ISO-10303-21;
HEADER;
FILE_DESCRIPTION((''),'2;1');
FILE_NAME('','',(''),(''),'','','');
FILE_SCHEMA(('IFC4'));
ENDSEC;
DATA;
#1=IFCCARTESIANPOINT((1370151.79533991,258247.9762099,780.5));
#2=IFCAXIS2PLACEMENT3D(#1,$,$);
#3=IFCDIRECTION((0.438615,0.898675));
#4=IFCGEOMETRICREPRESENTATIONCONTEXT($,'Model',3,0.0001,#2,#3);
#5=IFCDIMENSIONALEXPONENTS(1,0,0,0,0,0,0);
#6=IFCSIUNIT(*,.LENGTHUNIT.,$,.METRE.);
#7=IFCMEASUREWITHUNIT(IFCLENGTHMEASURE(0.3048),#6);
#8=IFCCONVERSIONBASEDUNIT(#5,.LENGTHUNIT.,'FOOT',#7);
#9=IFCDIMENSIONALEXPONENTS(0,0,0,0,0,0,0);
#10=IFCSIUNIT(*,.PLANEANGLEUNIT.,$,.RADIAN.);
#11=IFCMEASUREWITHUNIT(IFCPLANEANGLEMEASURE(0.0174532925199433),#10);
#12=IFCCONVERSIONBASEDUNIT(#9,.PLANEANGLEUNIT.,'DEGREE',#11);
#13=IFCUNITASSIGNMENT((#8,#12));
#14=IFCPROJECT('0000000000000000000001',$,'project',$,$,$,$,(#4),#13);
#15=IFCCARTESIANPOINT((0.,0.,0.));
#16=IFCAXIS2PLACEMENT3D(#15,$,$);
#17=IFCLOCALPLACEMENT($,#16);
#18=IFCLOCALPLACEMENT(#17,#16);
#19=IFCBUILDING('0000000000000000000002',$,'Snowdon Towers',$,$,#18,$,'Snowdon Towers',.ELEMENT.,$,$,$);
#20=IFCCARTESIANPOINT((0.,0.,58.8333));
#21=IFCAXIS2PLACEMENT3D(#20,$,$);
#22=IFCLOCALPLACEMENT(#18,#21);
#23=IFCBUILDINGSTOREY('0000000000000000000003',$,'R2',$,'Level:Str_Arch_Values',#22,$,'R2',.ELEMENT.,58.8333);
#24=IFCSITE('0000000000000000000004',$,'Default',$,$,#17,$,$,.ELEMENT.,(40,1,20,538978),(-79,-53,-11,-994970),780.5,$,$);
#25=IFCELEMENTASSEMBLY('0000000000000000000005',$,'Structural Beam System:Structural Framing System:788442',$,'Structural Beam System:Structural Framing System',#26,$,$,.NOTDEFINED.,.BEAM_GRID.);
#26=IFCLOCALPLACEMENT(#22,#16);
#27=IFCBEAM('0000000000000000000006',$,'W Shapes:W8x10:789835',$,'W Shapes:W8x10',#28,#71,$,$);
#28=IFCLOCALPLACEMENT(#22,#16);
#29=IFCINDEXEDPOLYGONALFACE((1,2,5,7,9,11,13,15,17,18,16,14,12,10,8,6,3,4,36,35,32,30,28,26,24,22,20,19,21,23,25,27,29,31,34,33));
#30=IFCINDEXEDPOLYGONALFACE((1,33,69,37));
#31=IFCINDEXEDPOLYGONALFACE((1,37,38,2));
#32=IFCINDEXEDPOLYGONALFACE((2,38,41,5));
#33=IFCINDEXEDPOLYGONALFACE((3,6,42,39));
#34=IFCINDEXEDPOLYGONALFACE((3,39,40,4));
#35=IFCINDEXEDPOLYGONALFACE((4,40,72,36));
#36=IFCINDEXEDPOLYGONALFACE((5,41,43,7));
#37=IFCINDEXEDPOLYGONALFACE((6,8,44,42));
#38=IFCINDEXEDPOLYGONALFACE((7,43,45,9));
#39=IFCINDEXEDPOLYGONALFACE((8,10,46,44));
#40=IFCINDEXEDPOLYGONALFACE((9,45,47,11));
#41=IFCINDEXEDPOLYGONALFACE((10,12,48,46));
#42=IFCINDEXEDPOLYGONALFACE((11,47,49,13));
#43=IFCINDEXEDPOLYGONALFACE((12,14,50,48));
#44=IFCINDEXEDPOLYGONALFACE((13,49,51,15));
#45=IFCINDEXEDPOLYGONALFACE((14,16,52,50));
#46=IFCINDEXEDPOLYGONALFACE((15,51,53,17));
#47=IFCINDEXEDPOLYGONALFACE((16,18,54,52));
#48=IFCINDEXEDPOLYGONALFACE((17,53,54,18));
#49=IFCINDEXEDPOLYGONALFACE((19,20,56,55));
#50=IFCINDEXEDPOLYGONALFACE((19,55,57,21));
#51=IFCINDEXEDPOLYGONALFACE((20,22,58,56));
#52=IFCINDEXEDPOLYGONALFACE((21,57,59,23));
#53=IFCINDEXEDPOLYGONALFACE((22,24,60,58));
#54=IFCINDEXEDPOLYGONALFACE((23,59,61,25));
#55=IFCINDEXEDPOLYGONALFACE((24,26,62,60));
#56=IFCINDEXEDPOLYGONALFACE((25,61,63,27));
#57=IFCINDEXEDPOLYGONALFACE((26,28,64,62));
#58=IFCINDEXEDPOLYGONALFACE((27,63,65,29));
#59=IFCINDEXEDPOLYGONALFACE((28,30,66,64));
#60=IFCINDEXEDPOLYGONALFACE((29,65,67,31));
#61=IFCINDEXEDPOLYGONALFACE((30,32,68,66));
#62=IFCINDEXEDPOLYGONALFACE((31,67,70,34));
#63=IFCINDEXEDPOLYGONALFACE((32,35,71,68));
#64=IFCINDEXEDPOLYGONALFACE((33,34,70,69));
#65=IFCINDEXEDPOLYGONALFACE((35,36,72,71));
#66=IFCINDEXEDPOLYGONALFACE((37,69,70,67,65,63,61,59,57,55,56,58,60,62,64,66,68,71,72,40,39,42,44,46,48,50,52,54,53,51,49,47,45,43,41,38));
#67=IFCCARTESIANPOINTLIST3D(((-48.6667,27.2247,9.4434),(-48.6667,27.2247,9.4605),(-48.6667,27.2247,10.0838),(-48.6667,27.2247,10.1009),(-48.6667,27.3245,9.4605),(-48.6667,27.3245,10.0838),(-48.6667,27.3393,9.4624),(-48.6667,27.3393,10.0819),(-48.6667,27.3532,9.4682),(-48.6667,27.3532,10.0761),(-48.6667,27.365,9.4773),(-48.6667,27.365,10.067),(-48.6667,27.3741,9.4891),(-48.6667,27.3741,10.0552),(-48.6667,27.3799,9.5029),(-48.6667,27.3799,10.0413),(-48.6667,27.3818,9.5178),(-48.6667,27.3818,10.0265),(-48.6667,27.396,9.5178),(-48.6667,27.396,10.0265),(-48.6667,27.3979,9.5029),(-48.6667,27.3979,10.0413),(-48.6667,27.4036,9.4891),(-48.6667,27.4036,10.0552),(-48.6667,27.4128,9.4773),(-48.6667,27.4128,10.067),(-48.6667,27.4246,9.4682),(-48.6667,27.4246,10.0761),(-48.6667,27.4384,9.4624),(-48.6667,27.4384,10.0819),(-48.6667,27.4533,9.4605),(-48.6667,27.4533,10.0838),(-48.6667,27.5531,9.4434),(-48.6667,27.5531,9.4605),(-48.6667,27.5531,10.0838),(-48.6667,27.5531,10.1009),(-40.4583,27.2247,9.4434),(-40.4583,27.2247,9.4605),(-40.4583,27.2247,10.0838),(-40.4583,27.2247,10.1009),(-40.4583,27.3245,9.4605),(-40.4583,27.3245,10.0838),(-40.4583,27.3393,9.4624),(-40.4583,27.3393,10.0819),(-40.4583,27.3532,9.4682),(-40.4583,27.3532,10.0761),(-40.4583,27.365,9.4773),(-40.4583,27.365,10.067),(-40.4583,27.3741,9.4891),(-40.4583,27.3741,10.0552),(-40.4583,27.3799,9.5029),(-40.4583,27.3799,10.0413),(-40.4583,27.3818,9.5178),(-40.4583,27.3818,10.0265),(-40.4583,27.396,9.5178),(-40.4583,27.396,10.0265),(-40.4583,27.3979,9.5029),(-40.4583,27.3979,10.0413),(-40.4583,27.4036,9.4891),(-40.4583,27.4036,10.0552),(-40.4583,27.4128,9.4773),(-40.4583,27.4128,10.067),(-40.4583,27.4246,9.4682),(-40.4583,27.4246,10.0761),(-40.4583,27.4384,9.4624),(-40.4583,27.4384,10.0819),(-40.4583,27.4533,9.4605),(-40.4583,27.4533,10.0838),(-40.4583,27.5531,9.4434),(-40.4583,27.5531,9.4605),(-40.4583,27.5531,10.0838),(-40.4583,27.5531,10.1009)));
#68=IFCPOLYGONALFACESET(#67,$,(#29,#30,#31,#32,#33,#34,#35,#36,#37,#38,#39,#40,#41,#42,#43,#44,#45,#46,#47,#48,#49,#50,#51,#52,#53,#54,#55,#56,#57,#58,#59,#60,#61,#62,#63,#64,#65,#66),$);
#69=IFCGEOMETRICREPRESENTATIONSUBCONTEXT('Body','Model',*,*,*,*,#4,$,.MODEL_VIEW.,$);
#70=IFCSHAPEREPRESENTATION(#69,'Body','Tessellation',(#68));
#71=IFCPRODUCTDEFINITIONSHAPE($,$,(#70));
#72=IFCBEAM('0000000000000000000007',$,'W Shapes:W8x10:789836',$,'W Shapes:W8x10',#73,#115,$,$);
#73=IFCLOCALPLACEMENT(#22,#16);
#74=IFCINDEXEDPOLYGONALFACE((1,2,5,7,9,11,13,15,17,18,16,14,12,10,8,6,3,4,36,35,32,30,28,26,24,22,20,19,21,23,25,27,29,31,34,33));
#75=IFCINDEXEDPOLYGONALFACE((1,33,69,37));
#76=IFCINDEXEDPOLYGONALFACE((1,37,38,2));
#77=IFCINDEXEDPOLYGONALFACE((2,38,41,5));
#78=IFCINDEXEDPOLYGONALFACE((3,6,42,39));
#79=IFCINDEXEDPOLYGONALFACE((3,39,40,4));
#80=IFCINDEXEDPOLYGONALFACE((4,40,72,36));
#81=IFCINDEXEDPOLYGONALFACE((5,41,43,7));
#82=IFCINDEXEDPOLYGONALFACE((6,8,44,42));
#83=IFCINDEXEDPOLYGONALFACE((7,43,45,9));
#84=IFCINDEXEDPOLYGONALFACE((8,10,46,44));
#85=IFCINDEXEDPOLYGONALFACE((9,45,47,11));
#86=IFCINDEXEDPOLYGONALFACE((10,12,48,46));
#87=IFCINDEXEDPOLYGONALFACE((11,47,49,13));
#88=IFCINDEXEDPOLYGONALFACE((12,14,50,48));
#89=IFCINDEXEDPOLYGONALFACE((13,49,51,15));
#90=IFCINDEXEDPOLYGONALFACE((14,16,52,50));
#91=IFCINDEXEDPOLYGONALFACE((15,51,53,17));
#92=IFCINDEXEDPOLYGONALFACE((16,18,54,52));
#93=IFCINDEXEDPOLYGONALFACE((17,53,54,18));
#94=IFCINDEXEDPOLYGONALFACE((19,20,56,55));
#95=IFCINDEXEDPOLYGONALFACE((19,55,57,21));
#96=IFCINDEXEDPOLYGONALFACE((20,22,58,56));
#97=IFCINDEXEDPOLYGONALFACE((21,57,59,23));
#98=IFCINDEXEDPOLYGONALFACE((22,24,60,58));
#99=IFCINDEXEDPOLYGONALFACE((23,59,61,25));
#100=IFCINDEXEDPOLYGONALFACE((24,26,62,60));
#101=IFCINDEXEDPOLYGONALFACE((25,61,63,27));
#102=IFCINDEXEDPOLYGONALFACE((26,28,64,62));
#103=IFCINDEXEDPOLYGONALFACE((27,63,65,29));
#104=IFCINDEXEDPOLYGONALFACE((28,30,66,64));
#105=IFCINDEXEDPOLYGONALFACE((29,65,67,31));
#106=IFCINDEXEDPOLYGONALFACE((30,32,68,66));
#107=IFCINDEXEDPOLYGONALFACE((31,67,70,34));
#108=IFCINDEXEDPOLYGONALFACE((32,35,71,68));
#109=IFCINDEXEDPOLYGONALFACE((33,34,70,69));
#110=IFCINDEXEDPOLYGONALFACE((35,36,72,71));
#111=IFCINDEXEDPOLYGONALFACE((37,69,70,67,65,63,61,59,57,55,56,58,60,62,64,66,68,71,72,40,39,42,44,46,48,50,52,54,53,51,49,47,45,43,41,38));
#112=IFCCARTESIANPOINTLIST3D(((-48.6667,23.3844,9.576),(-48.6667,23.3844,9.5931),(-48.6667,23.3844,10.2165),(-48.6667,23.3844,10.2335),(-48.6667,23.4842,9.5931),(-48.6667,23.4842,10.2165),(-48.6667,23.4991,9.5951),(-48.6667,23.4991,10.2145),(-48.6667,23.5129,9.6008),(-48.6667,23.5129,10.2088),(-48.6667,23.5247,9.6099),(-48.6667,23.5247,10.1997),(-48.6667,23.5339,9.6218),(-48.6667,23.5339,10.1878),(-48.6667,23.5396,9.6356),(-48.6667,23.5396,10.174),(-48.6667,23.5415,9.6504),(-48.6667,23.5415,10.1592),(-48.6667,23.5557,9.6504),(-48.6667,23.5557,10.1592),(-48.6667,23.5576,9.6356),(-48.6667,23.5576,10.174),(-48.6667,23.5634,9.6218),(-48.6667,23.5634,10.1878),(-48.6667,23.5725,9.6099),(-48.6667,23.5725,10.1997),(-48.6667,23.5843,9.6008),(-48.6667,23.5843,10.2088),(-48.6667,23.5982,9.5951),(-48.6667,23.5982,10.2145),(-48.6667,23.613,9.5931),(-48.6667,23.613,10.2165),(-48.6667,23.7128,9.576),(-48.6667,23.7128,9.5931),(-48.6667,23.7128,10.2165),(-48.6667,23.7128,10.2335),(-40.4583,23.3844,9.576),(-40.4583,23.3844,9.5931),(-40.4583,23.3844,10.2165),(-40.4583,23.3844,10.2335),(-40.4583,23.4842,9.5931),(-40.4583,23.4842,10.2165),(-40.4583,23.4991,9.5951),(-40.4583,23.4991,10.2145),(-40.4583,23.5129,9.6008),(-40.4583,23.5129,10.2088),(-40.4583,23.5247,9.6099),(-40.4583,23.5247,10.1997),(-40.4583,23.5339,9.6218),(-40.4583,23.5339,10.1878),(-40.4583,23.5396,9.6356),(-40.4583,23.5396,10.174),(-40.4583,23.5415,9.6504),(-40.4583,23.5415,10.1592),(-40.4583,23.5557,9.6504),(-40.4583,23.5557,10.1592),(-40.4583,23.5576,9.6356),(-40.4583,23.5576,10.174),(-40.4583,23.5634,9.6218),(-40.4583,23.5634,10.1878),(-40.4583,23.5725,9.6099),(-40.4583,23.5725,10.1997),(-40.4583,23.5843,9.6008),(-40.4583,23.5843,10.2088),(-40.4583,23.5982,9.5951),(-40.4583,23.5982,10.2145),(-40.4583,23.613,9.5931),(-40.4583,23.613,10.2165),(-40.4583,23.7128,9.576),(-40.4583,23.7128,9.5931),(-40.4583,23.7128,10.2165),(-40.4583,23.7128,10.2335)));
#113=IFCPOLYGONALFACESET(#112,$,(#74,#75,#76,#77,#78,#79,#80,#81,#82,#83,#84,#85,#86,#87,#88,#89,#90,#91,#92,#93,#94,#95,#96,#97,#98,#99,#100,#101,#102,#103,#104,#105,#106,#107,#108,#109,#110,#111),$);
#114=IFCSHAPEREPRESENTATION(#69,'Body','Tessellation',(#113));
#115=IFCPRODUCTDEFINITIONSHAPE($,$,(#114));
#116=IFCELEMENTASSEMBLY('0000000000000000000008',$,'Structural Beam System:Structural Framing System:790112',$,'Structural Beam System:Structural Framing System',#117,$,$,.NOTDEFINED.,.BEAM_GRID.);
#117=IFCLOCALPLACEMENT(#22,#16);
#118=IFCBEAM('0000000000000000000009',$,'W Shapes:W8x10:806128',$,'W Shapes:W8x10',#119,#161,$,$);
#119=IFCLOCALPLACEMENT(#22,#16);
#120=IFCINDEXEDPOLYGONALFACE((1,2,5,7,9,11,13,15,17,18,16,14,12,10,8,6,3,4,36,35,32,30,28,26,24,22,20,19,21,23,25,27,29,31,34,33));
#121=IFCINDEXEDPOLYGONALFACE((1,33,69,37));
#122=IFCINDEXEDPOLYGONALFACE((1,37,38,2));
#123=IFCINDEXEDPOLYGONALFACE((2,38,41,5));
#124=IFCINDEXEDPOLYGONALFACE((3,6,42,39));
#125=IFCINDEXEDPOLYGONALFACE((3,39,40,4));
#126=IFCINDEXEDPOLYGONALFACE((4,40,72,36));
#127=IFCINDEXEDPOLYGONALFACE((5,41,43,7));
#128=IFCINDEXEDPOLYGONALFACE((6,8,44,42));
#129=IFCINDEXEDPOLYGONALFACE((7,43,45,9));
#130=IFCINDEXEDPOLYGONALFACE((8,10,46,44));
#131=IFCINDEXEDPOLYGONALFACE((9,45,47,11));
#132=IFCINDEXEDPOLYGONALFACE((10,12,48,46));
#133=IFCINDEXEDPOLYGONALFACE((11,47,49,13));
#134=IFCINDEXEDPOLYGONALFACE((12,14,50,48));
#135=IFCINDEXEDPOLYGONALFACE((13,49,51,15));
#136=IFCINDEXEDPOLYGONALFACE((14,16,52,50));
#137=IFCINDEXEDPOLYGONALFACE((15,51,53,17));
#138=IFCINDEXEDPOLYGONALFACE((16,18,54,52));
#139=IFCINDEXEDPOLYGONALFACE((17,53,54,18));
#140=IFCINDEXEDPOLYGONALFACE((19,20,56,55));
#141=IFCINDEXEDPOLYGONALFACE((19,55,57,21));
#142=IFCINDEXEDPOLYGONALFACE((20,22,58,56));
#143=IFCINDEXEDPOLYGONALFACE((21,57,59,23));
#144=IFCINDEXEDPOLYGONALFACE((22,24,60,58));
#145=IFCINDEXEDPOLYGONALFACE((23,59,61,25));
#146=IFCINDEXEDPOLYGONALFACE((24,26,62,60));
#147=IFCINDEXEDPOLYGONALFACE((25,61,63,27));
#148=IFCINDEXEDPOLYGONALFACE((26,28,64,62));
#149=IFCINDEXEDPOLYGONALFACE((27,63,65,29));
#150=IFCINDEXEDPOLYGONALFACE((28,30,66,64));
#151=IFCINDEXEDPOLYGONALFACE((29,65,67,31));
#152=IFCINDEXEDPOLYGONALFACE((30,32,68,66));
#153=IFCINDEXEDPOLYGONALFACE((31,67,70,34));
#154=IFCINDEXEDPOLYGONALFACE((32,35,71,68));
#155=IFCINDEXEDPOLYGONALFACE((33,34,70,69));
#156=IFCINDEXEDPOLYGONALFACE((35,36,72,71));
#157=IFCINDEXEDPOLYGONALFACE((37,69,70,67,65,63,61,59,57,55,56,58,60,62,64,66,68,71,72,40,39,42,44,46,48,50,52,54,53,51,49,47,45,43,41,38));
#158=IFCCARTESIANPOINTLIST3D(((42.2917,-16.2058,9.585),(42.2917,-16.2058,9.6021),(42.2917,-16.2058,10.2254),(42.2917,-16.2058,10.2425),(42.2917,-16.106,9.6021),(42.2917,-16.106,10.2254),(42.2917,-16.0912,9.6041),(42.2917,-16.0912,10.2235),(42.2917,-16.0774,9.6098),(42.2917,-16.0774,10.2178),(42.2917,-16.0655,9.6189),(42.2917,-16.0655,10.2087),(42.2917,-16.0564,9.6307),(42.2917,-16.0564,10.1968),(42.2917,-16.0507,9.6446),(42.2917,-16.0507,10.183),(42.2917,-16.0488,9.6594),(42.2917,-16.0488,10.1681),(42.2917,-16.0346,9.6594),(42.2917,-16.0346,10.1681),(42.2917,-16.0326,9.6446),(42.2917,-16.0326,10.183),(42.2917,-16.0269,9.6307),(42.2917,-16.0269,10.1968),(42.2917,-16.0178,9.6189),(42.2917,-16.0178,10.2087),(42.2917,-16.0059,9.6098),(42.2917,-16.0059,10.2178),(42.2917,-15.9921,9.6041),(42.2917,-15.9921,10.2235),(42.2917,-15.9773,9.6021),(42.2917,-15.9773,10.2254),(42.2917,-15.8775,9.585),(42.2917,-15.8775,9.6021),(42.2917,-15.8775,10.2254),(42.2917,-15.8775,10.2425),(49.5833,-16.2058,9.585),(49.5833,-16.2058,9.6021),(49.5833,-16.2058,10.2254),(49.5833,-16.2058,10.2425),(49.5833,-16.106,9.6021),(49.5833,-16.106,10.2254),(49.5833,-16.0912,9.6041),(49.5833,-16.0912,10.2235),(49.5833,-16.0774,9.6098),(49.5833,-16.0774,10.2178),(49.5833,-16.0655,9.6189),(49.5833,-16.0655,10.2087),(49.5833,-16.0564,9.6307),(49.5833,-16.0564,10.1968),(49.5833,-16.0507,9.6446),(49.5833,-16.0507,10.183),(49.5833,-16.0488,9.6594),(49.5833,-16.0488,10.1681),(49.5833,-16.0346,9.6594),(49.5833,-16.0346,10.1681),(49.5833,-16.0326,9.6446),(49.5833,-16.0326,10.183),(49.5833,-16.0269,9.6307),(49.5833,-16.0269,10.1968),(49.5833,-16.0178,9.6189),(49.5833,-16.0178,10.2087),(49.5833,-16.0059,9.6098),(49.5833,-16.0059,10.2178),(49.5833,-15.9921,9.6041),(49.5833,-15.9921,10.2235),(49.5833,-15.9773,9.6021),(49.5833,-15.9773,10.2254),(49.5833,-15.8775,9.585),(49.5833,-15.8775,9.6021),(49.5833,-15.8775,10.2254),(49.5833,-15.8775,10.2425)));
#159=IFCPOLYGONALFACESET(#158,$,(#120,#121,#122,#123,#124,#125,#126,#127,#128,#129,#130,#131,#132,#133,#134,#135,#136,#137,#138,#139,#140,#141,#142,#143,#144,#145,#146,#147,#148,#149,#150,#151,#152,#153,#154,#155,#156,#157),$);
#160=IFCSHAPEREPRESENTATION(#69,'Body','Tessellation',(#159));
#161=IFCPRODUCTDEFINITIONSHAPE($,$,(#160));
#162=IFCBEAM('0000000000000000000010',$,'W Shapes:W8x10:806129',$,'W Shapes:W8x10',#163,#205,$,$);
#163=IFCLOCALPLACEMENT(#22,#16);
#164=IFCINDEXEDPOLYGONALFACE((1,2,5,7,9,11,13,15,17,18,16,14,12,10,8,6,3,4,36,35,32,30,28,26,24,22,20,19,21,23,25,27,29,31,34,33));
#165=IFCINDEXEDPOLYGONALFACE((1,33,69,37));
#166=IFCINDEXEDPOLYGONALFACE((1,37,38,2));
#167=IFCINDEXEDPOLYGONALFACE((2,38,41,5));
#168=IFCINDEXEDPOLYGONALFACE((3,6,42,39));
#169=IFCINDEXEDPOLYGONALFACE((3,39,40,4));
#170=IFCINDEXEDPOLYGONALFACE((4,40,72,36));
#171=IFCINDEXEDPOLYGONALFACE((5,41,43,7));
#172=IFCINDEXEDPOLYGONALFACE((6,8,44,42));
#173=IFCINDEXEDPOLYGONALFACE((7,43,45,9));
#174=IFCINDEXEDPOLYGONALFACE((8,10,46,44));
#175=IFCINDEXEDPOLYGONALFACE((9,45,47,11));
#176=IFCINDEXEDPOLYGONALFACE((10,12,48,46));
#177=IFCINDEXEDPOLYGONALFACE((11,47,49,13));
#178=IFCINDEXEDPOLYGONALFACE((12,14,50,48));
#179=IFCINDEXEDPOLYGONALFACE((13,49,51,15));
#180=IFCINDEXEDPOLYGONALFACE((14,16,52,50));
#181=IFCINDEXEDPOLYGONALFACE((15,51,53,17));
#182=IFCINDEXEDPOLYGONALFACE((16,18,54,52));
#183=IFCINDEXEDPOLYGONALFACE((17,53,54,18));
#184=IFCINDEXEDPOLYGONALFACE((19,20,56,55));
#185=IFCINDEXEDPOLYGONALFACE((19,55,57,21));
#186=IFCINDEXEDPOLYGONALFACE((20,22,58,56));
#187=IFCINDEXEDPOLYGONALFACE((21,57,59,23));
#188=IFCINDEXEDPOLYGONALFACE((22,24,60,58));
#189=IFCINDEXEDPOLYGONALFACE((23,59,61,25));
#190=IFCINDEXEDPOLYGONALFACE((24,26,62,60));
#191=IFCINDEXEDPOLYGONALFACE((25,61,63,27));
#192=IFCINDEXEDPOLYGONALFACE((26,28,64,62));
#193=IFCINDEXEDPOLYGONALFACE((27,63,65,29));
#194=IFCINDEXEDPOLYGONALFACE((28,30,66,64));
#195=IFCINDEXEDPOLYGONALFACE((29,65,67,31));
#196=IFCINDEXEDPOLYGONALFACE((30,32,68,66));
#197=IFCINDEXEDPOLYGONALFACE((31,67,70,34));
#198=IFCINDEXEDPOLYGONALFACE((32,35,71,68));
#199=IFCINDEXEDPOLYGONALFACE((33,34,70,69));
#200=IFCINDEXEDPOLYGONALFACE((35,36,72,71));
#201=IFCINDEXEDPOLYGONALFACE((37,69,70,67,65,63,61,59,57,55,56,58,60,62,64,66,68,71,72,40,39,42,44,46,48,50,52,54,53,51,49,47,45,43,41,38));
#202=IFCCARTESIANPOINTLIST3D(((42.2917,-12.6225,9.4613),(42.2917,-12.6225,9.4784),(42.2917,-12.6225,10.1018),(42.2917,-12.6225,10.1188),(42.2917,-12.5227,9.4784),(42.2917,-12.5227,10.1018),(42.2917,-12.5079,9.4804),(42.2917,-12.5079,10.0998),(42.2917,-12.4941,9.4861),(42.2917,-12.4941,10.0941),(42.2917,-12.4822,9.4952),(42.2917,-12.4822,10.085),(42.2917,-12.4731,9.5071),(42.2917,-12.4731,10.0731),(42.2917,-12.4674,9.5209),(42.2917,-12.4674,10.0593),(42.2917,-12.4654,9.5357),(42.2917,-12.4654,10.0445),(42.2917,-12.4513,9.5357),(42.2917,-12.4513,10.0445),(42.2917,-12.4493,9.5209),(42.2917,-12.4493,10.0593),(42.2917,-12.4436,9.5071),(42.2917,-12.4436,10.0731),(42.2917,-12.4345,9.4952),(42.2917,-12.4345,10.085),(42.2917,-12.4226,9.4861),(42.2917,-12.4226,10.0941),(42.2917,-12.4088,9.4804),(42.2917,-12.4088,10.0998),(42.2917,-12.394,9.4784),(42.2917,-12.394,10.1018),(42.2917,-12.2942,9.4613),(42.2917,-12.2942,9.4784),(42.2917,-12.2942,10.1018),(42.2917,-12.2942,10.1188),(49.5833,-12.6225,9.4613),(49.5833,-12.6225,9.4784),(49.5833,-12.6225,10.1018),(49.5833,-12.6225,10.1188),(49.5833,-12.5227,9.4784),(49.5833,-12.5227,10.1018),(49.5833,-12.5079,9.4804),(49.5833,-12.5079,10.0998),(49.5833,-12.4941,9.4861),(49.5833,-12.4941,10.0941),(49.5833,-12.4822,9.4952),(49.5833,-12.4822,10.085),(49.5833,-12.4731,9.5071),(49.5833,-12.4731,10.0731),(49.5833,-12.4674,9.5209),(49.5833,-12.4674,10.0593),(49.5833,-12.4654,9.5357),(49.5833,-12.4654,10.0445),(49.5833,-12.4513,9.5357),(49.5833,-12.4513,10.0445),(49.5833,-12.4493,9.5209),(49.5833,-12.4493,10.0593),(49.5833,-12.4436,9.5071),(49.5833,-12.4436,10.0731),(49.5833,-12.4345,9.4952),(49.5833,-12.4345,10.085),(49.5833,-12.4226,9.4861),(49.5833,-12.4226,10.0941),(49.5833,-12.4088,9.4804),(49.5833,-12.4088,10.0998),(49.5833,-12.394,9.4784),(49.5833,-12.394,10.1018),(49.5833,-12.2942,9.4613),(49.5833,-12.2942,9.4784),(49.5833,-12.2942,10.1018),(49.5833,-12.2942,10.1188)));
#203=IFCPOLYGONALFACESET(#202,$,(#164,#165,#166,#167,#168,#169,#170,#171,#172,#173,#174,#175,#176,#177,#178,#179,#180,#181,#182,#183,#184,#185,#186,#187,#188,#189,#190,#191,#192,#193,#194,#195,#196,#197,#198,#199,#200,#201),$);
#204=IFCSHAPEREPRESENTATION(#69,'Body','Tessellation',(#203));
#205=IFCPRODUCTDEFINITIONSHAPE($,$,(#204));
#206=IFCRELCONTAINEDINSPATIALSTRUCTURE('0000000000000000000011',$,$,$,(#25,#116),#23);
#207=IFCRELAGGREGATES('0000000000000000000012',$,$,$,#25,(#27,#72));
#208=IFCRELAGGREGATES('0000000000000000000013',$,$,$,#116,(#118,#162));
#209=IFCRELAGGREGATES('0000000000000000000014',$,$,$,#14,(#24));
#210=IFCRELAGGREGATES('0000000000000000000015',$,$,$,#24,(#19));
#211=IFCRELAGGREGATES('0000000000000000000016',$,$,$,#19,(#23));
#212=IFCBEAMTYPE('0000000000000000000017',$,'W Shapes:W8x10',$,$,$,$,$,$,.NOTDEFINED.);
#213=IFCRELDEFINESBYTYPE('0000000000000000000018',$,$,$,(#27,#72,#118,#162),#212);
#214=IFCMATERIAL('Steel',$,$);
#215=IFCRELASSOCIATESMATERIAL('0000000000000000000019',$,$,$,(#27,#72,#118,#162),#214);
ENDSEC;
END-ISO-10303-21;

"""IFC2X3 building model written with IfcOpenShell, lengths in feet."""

from ifc_helpers import new_model, entity, si_unit, converted_unit, direction, frame, frame_2d, origin, place, context, subcontext, project, spatial, i_section, extrude, material, type_object, element, aggregate, save


model = new_model("IFC2X3")

# Units and contexts
model_context = context("Model", 3, precision=0.0001, world=frame((1370151.79533991, 258247.9762099, 780.5)), true_north=direction((0.438615, 0.898675)))
body_context = subcontext(model_context, "Body", "Model", "MODEL_VIEW")
ifc_project = project(units=[converted_unit("LENGTHUNIT", "FOOT", entity("IfcLengthMeasure", 0.3048), si_unit("LENGTHUNIT", "METRE"), dimensions=[1, 0, 0, 0, 0, 0, 0]), converted_unit("PLANEANGLEUNIT", "DEGREE", entity("IfcPlaneAngleMeasure", 0.0174532925199433), si_unit("PLANEANGLEUNIT", "RADIAN"), dimensions=[0, 0, 0, 0, 0, 0, 0])], contexts=[model_context])

# Site, building, storey
site_placement = place(None, origin())
site = spatial("IfcSite", under=ifc_project, at=site_placement, Name="Default", CompositionType="ELEMENT", RefLatitude=(40, 1, 20, 538978), RefLongitude=(-79, -53, -11, -994970), RefElevation=780.5)
building_placement = place(site_placement, origin())
building = spatial("IfcBuilding", under=site, at=building_placement, Name="Snowdon Towers", LongName="Snowdon Towers", CompositionType="ELEMENT")
storey_placement = place(building_placement, frame((0.0, 0.0, 58.8333)))
storey = spatial("IfcBuildingStorey", under=building, at=storey_placement, Name="R2", ObjectType="Level:Str_Arch_Values", LongName="R2", CompositionType="ELEMENT", Elevation=58.8333)

# Element assemblies, beams
ifc_material_1 = material(Name="Steel")
beam_type = type_object("IfcBeamType", Name="W Shapes:W8x10", PredefinedType="NOTDEFINED")
assembly_1_placement = place(storey_placement, origin())
assembly_1 = element("IfcElementAssembly", 1, at=assembly_1_placement, inside=storey, Name="Structural Beam System:Structural Framing System:788442", ObjectType="Structural Beam System:Structural Framing System", AssemblyPlace="NOTDEFINED", PredefinedType="BEAM_GRID")
beam_1_placement = place(assembly_1_placement, frame((-48.75, 27.3889, 10.1009)))
beam_1 = element("IfcBeam", 2, at=beam_1_placement, type_object=beam_type, material=ifc_material_1, Name="W Shapes:W8x10:789835", ObjectType="W Shapes:W8x10", context=body_context, shape_type="SweptSolid", body=[
    extrude(i_section(OverallWidth=0.3283, OverallDepth=0.6575, WebThickness=0.0142, FlangeThickness=0.0171, FilletRadius=0.0573, at=frame_2d((0.0, 0.0), x_axis=(0.0, 1.0))), frame((0.0833, 0.0, -0.3288), z_axis=(1.0, 0.0, 0.0), x_axis=(0.0, 0.0, -1.0)), (0.0, 0.0, 1.0), 8.2083),
])
beam_2_placement = place(assembly_1_placement, frame((-48.75, 23.5486, 10.2335)))
beam_2 = element("IfcBeam", 3, at=beam_2_placement, type_object=beam_type, material=ifc_material_1, Name="W Shapes:W8x10:789836", ObjectType="W Shapes:W8x10", context=body_context, shape_type="SweptSolid", body=[
    extrude(i_section(OverallWidth=0.3283, OverallDepth=0.6575, WebThickness=0.0142, FlangeThickness=0.0171, FilletRadius=0.0573, at=frame_2d((0.0, 0.0), x_axis=(0.0, 1.0))), frame((0.0833, 0.0, -0.3288), z_axis=(1.0, 0.0, 0.0), x_axis=(0.0, 0.0, -1.0)), (0.0, 0.0, 1.0), 8.2083),
])
aggregate(assembly_1, [beam_1, beam_2])
assembly_2_placement = place(storey_placement, origin())
assembly_2 = element("IfcElementAssembly", 4, at=assembly_2_placement, inside=storey, Name="Structural Beam System:Structural Framing System:790112", ObjectType="Structural Beam System:Structural Framing System", AssemblyPlace="NOTDEFINED", PredefinedType="BEAM_GRID")
beam_3_placement = place(assembly_2_placement, frame((50.125, -16.0417, 10.2425), z_axis=(0.0, 0.0, 1.0), x_axis=(-1.0, 0.0, 0.0)))
beam_3 = element("IfcBeam", 5, at=beam_3_placement, type_object=beam_type, material=ifc_material_1, Name="W Shapes:W8x10:806128", ObjectType="W Shapes:W8x10", context=body_context, shape_type="SweptSolid", body=[
    extrude(i_section(OverallWidth=0.3283, OverallDepth=0.6575, WebThickness=0.0142, FlangeThickness=0.0171, FilletRadius=0.0573, at=frame_2d((0.0, 0.0), x_axis=(0.0, 1.0))), frame((0.5417, 0.0, -0.3288), z_axis=(1.0, 0.0, 0.0), x_axis=(0.0, 0.0, -1.0)), (0.0, 0.0, 1.0), 7.2917),
])
beam_4_placement = place(assembly_2_placement, frame((50.125, -12.4583, 10.1188), z_axis=(0.0, 0.0, 1.0), x_axis=(-1.0, 0.0, 0.0)))
beam_4 = element("IfcBeam", 6, at=beam_4_placement, type_object=beam_type, material=ifc_material_1, Name="W Shapes:W8x10:806129", ObjectType="W Shapes:W8x10", context=body_context, shape_type="SweptSolid", body=[
    extrude(i_section(OverallWidth=0.3283, OverallDepth=0.6575, WebThickness=0.0142, FlangeThickness=0.0171, FilletRadius=0.0573, at=frame_2d((0.0, 0.0), x_axis=(0.0, 1.0))), frame((0.5417, 0.0, -0.3288), z_axis=(1.0, 0.0, 0.0), x_axis=(0.0, 0.0, -1.0)), (0.0, 0.0, 1.0), 7.2917),
])
aggregate(assembly_2, [beam_3, beam_4])

save(model, "model.ifc")
